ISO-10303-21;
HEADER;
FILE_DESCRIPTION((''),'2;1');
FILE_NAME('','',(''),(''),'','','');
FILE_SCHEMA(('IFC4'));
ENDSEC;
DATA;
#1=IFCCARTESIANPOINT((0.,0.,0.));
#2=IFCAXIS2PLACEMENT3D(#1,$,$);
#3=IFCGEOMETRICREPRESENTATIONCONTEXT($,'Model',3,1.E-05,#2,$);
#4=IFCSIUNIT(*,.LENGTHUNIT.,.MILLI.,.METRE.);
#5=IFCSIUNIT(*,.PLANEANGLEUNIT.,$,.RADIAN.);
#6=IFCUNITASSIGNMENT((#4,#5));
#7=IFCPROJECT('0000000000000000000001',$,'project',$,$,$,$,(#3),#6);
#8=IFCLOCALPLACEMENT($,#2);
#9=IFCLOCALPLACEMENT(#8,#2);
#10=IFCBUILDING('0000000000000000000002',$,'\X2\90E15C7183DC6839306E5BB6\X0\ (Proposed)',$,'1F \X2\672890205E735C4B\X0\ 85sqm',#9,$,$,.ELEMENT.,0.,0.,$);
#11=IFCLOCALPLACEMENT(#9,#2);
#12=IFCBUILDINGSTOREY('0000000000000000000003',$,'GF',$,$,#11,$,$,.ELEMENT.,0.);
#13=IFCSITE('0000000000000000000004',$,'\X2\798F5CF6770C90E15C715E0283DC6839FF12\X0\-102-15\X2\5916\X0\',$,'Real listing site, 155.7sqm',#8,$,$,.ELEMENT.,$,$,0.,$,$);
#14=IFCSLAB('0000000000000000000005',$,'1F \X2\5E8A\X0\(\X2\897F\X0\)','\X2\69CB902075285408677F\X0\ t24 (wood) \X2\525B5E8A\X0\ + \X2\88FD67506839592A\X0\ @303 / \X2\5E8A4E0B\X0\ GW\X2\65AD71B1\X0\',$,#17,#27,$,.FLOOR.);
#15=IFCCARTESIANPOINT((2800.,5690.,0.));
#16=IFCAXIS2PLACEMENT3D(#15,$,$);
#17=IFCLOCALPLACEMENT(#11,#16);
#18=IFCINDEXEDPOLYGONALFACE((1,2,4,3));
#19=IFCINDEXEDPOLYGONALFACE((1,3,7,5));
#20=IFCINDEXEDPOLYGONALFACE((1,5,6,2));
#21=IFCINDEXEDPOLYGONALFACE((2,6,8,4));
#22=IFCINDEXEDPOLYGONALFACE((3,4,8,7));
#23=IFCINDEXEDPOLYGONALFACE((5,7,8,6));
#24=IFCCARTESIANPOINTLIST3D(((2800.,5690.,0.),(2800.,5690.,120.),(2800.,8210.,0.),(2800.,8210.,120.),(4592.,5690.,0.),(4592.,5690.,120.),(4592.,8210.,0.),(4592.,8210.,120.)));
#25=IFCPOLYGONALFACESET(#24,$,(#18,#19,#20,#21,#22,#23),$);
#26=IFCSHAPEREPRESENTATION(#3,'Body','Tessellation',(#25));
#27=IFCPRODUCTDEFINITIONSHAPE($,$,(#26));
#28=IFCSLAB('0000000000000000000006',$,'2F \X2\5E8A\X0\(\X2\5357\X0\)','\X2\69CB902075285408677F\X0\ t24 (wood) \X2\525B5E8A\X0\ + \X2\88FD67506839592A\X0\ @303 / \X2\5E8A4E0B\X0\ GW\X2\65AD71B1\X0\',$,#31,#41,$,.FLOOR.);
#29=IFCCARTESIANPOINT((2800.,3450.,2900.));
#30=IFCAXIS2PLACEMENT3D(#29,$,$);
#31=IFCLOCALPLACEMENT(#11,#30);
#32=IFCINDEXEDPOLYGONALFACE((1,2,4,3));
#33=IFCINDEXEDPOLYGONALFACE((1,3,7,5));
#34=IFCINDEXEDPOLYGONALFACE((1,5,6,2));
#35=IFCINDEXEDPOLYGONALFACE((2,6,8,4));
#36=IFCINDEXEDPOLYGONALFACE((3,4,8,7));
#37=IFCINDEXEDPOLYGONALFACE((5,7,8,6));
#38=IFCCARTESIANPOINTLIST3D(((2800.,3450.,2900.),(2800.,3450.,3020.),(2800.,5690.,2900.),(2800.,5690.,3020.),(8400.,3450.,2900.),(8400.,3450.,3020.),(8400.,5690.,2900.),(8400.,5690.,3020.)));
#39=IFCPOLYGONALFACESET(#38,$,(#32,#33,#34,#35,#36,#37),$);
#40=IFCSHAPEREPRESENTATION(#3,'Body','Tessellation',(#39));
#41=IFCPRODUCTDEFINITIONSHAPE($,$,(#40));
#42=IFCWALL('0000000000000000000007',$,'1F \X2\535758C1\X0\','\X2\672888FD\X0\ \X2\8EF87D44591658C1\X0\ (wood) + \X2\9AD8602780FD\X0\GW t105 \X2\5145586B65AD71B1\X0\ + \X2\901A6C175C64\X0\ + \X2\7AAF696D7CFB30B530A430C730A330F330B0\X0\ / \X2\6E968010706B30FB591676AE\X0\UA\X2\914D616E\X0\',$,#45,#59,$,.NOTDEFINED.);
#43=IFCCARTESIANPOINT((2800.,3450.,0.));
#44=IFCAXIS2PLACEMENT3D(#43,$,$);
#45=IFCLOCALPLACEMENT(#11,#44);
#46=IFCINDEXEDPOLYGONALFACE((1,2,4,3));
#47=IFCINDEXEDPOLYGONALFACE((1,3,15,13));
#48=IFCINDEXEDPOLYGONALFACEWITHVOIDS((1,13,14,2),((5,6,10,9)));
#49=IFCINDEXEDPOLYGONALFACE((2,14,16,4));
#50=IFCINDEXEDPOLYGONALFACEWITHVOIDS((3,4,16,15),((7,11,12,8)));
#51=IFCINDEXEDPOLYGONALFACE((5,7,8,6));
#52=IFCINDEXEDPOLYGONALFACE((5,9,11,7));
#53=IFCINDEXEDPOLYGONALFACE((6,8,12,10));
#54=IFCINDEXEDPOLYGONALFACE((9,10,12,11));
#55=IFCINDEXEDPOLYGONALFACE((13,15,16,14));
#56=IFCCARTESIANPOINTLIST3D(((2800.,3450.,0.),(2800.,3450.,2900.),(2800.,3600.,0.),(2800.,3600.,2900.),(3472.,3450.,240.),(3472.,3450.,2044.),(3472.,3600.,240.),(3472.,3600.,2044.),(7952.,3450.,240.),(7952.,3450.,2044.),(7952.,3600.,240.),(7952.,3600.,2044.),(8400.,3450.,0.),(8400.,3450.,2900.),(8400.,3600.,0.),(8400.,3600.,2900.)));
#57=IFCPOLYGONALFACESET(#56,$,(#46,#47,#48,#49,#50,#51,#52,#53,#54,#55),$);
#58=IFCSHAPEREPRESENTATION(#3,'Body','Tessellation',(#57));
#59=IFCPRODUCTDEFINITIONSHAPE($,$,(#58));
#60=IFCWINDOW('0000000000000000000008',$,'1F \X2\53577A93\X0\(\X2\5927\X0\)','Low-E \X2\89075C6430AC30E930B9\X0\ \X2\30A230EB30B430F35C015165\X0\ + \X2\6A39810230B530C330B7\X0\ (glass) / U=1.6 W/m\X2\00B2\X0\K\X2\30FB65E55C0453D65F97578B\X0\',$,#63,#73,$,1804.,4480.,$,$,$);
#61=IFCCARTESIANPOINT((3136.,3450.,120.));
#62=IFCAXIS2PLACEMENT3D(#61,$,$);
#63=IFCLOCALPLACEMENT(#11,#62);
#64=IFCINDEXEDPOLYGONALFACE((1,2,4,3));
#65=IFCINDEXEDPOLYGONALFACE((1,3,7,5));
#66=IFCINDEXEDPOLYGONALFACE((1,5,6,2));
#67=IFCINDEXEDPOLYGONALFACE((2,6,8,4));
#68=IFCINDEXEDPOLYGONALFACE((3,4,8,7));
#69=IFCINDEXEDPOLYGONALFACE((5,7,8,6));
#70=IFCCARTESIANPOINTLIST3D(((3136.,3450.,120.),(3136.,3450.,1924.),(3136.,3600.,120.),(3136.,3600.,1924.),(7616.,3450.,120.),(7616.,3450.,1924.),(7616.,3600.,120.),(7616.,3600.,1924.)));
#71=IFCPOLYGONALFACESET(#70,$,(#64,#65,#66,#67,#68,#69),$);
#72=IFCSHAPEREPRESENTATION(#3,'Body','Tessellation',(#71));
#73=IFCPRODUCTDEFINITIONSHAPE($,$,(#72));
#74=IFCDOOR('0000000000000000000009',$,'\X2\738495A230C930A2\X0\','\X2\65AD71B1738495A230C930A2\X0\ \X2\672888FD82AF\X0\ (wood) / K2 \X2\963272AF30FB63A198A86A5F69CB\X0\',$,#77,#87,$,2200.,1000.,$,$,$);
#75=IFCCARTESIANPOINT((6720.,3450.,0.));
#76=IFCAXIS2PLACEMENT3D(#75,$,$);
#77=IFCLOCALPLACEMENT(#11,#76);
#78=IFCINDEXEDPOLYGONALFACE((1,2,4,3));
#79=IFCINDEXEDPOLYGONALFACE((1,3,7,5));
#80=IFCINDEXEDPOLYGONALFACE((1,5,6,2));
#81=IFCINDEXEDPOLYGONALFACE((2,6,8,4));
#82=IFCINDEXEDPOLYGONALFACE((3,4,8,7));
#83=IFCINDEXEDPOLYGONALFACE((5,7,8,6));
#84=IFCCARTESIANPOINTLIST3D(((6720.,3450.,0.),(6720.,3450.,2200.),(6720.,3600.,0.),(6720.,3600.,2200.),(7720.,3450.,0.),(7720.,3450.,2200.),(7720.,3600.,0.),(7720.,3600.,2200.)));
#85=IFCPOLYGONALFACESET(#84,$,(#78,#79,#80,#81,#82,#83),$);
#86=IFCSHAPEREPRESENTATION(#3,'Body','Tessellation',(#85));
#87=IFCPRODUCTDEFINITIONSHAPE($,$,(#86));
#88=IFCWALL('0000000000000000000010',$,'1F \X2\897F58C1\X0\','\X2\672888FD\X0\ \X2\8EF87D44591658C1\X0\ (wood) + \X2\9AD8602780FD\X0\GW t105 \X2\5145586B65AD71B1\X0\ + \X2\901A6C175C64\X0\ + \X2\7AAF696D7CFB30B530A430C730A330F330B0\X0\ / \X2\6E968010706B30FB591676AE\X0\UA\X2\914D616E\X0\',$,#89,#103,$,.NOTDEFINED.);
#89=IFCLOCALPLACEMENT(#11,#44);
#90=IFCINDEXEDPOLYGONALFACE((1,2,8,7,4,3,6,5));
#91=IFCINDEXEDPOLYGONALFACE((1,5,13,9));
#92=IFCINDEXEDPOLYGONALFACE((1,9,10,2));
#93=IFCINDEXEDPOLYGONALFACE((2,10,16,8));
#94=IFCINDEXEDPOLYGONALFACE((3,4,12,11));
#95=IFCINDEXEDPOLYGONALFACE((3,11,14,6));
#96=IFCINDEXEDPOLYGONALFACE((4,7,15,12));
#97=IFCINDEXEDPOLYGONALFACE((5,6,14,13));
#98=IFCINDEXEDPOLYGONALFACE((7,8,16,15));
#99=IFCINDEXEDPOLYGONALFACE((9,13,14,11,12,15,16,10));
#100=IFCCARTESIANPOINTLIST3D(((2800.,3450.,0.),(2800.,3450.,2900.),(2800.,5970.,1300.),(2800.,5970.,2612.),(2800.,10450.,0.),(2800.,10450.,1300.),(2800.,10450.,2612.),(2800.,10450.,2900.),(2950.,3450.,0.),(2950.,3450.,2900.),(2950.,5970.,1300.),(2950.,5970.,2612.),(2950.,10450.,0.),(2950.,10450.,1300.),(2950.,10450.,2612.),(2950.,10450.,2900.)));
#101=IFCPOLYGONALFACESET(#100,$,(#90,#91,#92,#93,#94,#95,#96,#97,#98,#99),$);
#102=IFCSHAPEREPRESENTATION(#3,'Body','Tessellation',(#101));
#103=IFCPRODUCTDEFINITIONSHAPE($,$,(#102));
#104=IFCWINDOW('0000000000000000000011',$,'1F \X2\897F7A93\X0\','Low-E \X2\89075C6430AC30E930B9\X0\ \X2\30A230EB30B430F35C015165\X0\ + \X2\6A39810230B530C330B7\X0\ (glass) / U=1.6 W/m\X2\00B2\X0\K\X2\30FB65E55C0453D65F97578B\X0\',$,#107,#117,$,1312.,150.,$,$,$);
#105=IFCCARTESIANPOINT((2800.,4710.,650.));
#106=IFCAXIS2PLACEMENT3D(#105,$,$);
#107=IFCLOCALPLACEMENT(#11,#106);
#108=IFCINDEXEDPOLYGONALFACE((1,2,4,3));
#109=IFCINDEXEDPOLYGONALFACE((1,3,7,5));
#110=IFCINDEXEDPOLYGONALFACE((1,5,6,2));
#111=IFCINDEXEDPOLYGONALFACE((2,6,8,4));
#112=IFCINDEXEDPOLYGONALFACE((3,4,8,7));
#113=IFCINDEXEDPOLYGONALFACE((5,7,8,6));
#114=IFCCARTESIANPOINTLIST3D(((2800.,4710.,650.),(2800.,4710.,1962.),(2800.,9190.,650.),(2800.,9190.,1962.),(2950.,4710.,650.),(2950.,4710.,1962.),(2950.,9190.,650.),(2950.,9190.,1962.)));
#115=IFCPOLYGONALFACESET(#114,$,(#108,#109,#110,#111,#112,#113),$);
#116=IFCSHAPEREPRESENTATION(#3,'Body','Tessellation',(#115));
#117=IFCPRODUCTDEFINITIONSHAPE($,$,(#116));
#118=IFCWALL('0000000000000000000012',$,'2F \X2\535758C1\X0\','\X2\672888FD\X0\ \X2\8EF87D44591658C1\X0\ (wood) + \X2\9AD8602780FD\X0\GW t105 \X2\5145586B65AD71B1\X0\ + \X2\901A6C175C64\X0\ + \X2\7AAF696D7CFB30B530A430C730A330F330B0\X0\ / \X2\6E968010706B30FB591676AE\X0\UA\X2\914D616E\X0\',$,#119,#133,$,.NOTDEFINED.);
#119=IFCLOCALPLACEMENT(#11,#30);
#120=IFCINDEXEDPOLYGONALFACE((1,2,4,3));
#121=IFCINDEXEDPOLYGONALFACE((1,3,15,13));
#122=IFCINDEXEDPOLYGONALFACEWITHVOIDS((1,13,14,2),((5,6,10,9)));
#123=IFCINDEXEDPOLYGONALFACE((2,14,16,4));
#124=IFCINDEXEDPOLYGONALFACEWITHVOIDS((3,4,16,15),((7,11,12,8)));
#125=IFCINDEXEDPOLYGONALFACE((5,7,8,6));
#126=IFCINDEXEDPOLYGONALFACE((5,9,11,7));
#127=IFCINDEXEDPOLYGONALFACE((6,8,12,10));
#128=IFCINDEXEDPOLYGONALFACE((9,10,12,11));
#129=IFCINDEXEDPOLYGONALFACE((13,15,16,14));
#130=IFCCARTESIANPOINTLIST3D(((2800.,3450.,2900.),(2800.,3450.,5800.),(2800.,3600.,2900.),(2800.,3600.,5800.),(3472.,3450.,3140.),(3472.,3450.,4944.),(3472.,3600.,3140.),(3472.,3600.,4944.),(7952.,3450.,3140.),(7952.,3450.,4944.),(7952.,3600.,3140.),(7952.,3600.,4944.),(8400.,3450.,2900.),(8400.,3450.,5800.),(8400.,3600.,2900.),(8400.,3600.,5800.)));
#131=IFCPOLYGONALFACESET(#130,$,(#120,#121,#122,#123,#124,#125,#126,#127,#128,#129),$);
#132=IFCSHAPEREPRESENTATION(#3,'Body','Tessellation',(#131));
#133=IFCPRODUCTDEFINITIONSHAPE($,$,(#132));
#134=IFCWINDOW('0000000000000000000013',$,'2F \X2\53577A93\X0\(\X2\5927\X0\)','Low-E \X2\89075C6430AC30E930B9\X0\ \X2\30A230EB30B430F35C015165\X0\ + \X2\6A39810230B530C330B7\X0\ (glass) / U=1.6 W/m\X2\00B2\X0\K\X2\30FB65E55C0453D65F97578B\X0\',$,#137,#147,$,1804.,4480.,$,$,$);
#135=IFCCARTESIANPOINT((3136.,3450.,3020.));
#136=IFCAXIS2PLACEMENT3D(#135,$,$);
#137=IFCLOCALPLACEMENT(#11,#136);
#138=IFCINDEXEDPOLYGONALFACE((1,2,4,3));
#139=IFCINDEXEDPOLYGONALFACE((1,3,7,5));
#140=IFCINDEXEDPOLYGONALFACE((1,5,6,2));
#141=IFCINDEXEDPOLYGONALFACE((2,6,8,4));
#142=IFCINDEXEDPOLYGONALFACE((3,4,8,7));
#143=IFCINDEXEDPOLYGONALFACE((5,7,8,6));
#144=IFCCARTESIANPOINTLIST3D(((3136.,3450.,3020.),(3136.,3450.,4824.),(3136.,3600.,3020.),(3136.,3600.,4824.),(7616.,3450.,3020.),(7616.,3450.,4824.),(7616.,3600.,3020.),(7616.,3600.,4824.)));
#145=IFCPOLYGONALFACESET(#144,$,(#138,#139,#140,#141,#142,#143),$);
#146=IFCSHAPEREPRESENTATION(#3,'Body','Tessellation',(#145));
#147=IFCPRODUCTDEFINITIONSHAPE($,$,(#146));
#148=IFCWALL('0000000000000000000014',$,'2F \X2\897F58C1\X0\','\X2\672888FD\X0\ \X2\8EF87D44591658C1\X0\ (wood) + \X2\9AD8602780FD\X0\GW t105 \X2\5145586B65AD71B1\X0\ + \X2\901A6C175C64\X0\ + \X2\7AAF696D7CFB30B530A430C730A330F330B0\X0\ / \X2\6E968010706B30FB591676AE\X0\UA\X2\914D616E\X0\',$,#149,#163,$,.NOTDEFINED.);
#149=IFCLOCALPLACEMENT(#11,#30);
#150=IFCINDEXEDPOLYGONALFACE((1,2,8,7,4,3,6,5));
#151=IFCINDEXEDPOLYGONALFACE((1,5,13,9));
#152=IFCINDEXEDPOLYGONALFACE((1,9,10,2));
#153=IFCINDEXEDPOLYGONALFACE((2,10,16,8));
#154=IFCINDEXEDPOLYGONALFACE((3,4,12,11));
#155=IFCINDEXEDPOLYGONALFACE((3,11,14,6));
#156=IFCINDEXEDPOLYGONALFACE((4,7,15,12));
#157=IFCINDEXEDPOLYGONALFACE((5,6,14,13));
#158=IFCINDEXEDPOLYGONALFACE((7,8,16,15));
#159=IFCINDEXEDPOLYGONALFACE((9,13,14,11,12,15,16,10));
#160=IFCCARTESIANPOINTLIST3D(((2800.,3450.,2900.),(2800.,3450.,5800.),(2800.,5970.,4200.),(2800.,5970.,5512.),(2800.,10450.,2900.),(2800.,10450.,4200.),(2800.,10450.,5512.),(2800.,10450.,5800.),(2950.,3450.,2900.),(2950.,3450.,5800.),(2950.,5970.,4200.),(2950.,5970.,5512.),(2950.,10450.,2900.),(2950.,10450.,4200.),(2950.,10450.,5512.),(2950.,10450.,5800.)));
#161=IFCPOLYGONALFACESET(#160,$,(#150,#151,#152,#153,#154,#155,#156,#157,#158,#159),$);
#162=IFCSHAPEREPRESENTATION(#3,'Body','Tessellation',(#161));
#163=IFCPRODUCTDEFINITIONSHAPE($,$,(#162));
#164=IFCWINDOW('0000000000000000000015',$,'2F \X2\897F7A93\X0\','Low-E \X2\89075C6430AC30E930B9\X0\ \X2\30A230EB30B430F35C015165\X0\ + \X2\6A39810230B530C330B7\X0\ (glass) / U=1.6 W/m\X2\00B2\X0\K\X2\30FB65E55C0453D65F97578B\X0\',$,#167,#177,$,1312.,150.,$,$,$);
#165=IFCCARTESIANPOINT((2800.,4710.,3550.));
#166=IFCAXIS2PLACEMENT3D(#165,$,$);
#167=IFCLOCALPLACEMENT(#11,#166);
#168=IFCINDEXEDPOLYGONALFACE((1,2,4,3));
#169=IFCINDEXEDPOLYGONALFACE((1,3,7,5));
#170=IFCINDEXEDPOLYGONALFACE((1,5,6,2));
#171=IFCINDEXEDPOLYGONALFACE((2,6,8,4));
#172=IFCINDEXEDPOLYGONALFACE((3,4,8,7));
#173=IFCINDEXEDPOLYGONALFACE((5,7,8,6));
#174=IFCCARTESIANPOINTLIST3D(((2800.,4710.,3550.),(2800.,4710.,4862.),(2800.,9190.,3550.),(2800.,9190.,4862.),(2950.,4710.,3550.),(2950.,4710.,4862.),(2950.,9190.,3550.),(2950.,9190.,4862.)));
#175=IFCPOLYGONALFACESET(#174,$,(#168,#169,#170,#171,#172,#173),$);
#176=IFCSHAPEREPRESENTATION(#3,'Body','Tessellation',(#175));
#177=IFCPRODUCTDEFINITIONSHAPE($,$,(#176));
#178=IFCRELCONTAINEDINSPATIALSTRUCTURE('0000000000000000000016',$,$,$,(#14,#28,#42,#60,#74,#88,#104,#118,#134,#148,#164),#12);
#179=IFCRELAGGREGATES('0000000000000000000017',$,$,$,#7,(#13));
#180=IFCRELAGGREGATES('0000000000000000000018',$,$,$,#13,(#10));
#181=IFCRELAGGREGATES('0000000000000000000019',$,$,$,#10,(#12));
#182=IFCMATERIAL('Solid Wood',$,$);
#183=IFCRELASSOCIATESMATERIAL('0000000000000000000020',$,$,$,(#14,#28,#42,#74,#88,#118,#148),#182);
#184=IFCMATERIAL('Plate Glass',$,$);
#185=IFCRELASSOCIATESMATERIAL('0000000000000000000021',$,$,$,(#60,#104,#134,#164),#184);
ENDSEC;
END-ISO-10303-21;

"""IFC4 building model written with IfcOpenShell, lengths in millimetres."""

from ifc_helpers import new_model, si_unit, frame, frame_2d, origin, place, context, project, spatial, rectangle, extrude, material, element, fill, save


model = new_model("IFC4")

# Units and contexts
model_context = context("Model", 3, precision=1e-05, world=origin())
ifc_project = project(units=[si_unit("LENGTHUNIT", "METRE", prefix="MILLI"), si_unit("PLANEANGLEUNIT", "RADIAN")], contexts=[model_context])

# Site, building, storey
site_placement = place(None, origin())
site = spatial("IfcSite", under=ifc_project, at=site_placement, Name="福島県郡山市菜根２-102-15外", ObjectType="Real listing site, 155.7sqm", CompositionType="ELEMENT", RefElevation=0.0)
building_placement = place(site_placement, origin())
building = spatial("IfcBuilding", under=site, at=building_placement, Name="郡山菜根の家 (Proposed)", ObjectType="1F 木造平屋 85sqm", CompositionType="ELEMENT", ElevationOfRefHeight=0.0, ElevationOfTerrain=0.0)
storey_placement = place(building_placement, origin())
storey = spatial("IfcBuildingStorey", under=building, at=storey_placement, Name="GF", CompositionType="ELEMENT", Elevation=0.0)

# Slabs
ifc_material_1 = material(Name="Solid Wood")
slab_1_placement = place(storey_placement, frame((2800.0, 5690.0, 0.0)))
element("IfcSlab", 1, at=slab_1_placement, inside=storey, material=ifc_material_1, Name="1F 床(西)", Description="構造用合板 t24 (wood) 剛床 + 製材根太 @303 / 床下 GW断熱", PredefinedType="FLOOR", context=model_context, shape_type="SweptSolid", body=[
    extrude(rectangle(XDim=1792.0, YDim=2520.0, at=frame_2d((896.0, 1260.0))), frame((2800.0, 5690.0, 0.0)), (0.0, 0.0, 1.0), 120.0),
])
slab_2_placement = place(storey_placement, frame((2800.0, 3450.0, 2900.0)))
element("IfcSlab", 2, at=slab_2_placement, inside=storey, material=ifc_material_1, Name="2F 床(南)", Description="構造用合板 t24 (wood) 剛床 + 製材根太 @303 / 床下 GW断熱", PredefinedType="FLOOR", context=model_context, shape_type="SweptSolid", body=[
    extrude(rectangle(XDim=5600.0, YDim=2240.0, at=frame_2d((2800.0, 1120.0))), frame((2800.0, 3450.0, 2900.0)), (0.0, 0.0, 1.0), 120.0),
])

# Wall, openings, window, door
wall_1_placement = place(storey_placement, frame((2800.0, 3450.0, 0.0)))
wall_1 = element("IfcWall", 3, at=wall_1_placement, inside=storey, material=ifc_material_1, Name="1F 南壁", Description="木製 軸組外壁 (wood) + 高性能GW t105 充填断熱 + 通気層 + 窯業系サイディング / 準耐火・外皮UA配慮", PredefinedType="NOTDEFINED", context=model_context, shape_type="SweptSolid", body=[
    extrude(rectangle(XDim=5600.0, YDim=150.0, at=frame_2d((2800.0, 75.0))), frame((2800.0, 3450.0, 0.0)), (0.0, 0.0, 1.0), 2900.0),
])
opening_1_placement = place(storey_placement, frame((3136.0, 3450.0, 120.0)))
opening_1 = element("IfcOpeningElement", 4, at=opening_1_placement, cuts=wall_1, PredefinedType="NOTDEFINED", context=model_context, shape_type="SweptSolid", body=[
    extrude(rectangle(XDim=4480.0, YDim=150.0, at=frame_2d((2240.0, 75.0))), frame((3136.0, 3450.0, 120.0)), (0.0, 0.0, 1.0), 1804.0),
])
opening_2_placement = place(storey_placement, frame((6720.0, 3450.0, 0.0)))
opening_2 = element("IfcOpeningElement", 5, at=opening_2_placement, cuts=wall_1, PredefinedType="NOTDEFINED", context=model_context, shape_type="SweptSolid", body=[
    extrude(rectangle(XDim=1000.0, YDim=150.0, at=frame_2d((500.0, 75.0))), frame((6720.0, 3450.0, 0.0)), (0.0, 0.0, 1.0), 2200.0),
])
ifc_material_2 = material(Name="Plate Glass")
window_1_placement = place(storey_placement, frame((3136.0, 3450.0, 120.0)))
window_1 = element("IfcWindow", 6, at=window_1_placement, inside=storey, material=ifc_material_2, Name="1F 南窓(大)", Description="Low-E 複層ガラス アルゴン封入 + 樹脂サッシ (glass) / U=1.6 W/m²K・日射取得型", OverallHeight=1804.0, OverallWidth=4480.0, context=model_context, shape_type="SweptSolid", body=[
    extrude(rectangle(XDim=4480.0, YDim=150.0, at=frame_2d((2240.0, 75.0))), frame((3136.0, 3450.0, 120.0)), (0.0, 0.0, 1.0), 1804.0),
])
fill(opening_1, window_1)
door_placement = place(storey_placement, frame((6720.0, 3450.0, 0.0)))
door = element("IfcDoor", 7, at=door_placement, inside=storey, material=ifc_material_1, Name="玄関ドア", Description="断熱玄関ドア 木製芯 (wood) / K2 防犯・採風機構", OverallHeight=2200.0, OverallWidth=1000.0, context=model_context, shape_type="SweptSolid", body=[
    extrude(rectangle(XDim=1000.0, YDim=150.0, at=frame_2d((500.0, 75.0))), frame((6720.0, 3450.0, 0.0)), (0.0, 0.0, 1.0), 2200.0),
])
fill(opening_2, door)

# Walls, openings, windows
wall_2_placement = place(storey_placement, frame((2800.0, 3450.0, 0.0)))
wall_2 = element("IfcWall", 8, at=wall_2_placement, inside=storey, material=ifc_material_1, Name="1F 西壁", Description="木製 軸組外壁 (wood) + 高性能GW t105 充填断熱 + 通気層 + 窯業系サイディング / 準耐火・外皮UA配慮", PredefinedType="NOTDEFINED", context=model_context, shape_type="SweptSolid", body=[
    extrude(rectangle(XDim=150.0, YDim=7000.0, at=frame_2d((75.0, 3500.0))), frame((2800.0, 3450.0, 0.0)), (0.0, 0.0, 1.0), 2900.0),
])
opening_3_placement = place(storey_placement, frame((2800.0, 4710.0, 650.0)))
opening_3 = element("IfcOpeningElement", 9, at=opening_3_placement, cuts=wall_2, PredefinedType="NOTDEFINED", context=model_context, shape_type="SweptSolid", body=[
    extrude(rectangle(XDim=150.0, YDim=4480.0, at=frame_2d((75.0, 2240.0))), frame((2800.0, 4710.0, 650.0)), (0.0, 0.0, 1.0), 1312.0),
])
window_2_placement = place(storey_placement, frame((2800.0, 4710.0, 650.0)))
window_2 = element("IfcWindow", 10, at=window_2_placement, inside=storey, material=ifc_material_2, Name="1F 西窓", Description="Low-E 複層ガラス アルゴン封入 + 樹脂サッシ (glass) / U=1.6 W/m²K・日射取得型", OverallHeight=1312.0, OverallWidth=150.0, context=model_context, shape_type="SweptSolid", body=[
    extrude(rectangle(XDim=150.0, YDim=4480.0, at=frame_2d((75.0, 2240.0))), frame((2800.0, 4710.0, 650.0)), (0.0, 0.0, 1.0), 1312.0),
])
fill(opening_3, window_2)
wall_3_placement = place(storey_placement, frame((2800.0, 3450.0, 2900.0)))
wall_3 = element("IfcWall", 11, at=wall_3_placement, inside=storey, material=ifc_material_1, Name="2F 南壁", Description="木製 軸組外壁 (wood) + 高性能GW t105 充填断熱 + 通気層 + 窯業系サイディング / 準耐火・外皮UA配慮", PredefinedType="NOTDEFINED", context=model_context, shape_type="SweptSolid", body=[
    extrude(rectangle(XDim=5600.0, YDim=150.0, at=frame_2d((2800.0, 75.0))), frame((2800.0, 3450.0, 2900.0)), (0.0, 0.0, 1.0), 2900.0),
])
opening_4_placement = place(storey_placement, frame((3136.0, 3450.0, 3020.0)))
opening_4 = element("IfcOpeningElement", 12, at=opening_4_placement, cuts=wall_3, PredefinedType="NOTDEFINED", context=model_context, shape_type="SweptSolid", body=[
    extrude(rectangle(XDim=4480.0, YDim=150.0, at=frame_2d((2240.0, 75.0))), frame((3136.0, 3450.0, 3020.0)), (0.0, 0.0, 1.0), 1804.0),
])
window_3_placement = place(storey_placement, frame((3136.0, 3450.0, 3020.0)))
window_3 = element("IfcWindow", 13, at=window_3_placement, inside=storey, material=ifc_material_2, Name="2F 南窓(大)", Description="Low-E 複層ガラス アルゴン封入 + 樹脂サッシ (glass) / U=1.6 W/m²K・日射取得型", OverallHeight=1804.0, OverallWidth=4480.0, context=model_context, shape_type="SweptSolid", body=[
    extrude(rectangle(XDim=4480.0, YDim=150.0, at=frame_2d((2240.0, 75.0))), frame((3136.0, 3450.0, 3020.0)), (0.0, 0.0, 1.0), 1804.0),
])
fill(opening_4, window_3)
wall_4_placement = place(storey_placement, frame((2800.0, 3450.0, 2900.0)))
wall_4 = element("IfcWall", 14, at=wall_4_placement, inside=storey, material=ifc_material_1, Name="2F 西壁", Description="木製 軸組外壁 (wood) + 高性能GW t105 充填断熱 + 通気層 + 窯業系サイディング / 準耐火・外皮UA配慮", PredefinedType="NOTDEFINED", context=model_context, shape_type="SweptSolid", body=[
    extrude(rectangle(XDim=150.0, YDim=7000.0, at=frame_2d((75.0, 3500.0))), frame((2800.0, 3450.0, 2900.0)), (0.0, 0.0, 1.0), 2900.0),
])
opening_5_placement = place(storey_placement, frame((2800.0, 4710.0, 3550.0)))
opening_5 = element("IfcOpeningElement", 15, at=opening_5_placement, cuts=wall_4, PredefinedType="NOTDEFINED", context=model_context, shape_type="SweptSolid", body=[
    extrude(rectangle(XDim=150.0, YDim=4480.0, at=frame_2d((75.0, 2240.0))), frame((2800.0, 4710.0, 3550.0)), (0.0, 0.0, 1.0), 1312.0),
])
window_4_placement = place(storey_placement, frame((2800.0, 4710.0, 3550.0)))
window_4 = element("IfcWindow", 16, at=window_4_placement, inside=storey, material=ifc_material_2, Name="2F 西窓", Description="Low-E 複層ガラス アルゴン封入 + 樹脂サッシ (glass) / U=1.6 W/m²K・日射取得型", OverallHeight=1312.0, OverallWidth=150.0, context=model_context, shape_type="SweptSolid", body=[
    extrude(rectangle(XDim=150.0, YDim=4480.0, at=frame_2d((75.0, 2240.0))), frame((2800.0, 4710.0, 3550.0)), (0.0, 0.0, 1.0), 1312.0),
])
fill(opening_5, window_4)

save(model, "model.ifc")
